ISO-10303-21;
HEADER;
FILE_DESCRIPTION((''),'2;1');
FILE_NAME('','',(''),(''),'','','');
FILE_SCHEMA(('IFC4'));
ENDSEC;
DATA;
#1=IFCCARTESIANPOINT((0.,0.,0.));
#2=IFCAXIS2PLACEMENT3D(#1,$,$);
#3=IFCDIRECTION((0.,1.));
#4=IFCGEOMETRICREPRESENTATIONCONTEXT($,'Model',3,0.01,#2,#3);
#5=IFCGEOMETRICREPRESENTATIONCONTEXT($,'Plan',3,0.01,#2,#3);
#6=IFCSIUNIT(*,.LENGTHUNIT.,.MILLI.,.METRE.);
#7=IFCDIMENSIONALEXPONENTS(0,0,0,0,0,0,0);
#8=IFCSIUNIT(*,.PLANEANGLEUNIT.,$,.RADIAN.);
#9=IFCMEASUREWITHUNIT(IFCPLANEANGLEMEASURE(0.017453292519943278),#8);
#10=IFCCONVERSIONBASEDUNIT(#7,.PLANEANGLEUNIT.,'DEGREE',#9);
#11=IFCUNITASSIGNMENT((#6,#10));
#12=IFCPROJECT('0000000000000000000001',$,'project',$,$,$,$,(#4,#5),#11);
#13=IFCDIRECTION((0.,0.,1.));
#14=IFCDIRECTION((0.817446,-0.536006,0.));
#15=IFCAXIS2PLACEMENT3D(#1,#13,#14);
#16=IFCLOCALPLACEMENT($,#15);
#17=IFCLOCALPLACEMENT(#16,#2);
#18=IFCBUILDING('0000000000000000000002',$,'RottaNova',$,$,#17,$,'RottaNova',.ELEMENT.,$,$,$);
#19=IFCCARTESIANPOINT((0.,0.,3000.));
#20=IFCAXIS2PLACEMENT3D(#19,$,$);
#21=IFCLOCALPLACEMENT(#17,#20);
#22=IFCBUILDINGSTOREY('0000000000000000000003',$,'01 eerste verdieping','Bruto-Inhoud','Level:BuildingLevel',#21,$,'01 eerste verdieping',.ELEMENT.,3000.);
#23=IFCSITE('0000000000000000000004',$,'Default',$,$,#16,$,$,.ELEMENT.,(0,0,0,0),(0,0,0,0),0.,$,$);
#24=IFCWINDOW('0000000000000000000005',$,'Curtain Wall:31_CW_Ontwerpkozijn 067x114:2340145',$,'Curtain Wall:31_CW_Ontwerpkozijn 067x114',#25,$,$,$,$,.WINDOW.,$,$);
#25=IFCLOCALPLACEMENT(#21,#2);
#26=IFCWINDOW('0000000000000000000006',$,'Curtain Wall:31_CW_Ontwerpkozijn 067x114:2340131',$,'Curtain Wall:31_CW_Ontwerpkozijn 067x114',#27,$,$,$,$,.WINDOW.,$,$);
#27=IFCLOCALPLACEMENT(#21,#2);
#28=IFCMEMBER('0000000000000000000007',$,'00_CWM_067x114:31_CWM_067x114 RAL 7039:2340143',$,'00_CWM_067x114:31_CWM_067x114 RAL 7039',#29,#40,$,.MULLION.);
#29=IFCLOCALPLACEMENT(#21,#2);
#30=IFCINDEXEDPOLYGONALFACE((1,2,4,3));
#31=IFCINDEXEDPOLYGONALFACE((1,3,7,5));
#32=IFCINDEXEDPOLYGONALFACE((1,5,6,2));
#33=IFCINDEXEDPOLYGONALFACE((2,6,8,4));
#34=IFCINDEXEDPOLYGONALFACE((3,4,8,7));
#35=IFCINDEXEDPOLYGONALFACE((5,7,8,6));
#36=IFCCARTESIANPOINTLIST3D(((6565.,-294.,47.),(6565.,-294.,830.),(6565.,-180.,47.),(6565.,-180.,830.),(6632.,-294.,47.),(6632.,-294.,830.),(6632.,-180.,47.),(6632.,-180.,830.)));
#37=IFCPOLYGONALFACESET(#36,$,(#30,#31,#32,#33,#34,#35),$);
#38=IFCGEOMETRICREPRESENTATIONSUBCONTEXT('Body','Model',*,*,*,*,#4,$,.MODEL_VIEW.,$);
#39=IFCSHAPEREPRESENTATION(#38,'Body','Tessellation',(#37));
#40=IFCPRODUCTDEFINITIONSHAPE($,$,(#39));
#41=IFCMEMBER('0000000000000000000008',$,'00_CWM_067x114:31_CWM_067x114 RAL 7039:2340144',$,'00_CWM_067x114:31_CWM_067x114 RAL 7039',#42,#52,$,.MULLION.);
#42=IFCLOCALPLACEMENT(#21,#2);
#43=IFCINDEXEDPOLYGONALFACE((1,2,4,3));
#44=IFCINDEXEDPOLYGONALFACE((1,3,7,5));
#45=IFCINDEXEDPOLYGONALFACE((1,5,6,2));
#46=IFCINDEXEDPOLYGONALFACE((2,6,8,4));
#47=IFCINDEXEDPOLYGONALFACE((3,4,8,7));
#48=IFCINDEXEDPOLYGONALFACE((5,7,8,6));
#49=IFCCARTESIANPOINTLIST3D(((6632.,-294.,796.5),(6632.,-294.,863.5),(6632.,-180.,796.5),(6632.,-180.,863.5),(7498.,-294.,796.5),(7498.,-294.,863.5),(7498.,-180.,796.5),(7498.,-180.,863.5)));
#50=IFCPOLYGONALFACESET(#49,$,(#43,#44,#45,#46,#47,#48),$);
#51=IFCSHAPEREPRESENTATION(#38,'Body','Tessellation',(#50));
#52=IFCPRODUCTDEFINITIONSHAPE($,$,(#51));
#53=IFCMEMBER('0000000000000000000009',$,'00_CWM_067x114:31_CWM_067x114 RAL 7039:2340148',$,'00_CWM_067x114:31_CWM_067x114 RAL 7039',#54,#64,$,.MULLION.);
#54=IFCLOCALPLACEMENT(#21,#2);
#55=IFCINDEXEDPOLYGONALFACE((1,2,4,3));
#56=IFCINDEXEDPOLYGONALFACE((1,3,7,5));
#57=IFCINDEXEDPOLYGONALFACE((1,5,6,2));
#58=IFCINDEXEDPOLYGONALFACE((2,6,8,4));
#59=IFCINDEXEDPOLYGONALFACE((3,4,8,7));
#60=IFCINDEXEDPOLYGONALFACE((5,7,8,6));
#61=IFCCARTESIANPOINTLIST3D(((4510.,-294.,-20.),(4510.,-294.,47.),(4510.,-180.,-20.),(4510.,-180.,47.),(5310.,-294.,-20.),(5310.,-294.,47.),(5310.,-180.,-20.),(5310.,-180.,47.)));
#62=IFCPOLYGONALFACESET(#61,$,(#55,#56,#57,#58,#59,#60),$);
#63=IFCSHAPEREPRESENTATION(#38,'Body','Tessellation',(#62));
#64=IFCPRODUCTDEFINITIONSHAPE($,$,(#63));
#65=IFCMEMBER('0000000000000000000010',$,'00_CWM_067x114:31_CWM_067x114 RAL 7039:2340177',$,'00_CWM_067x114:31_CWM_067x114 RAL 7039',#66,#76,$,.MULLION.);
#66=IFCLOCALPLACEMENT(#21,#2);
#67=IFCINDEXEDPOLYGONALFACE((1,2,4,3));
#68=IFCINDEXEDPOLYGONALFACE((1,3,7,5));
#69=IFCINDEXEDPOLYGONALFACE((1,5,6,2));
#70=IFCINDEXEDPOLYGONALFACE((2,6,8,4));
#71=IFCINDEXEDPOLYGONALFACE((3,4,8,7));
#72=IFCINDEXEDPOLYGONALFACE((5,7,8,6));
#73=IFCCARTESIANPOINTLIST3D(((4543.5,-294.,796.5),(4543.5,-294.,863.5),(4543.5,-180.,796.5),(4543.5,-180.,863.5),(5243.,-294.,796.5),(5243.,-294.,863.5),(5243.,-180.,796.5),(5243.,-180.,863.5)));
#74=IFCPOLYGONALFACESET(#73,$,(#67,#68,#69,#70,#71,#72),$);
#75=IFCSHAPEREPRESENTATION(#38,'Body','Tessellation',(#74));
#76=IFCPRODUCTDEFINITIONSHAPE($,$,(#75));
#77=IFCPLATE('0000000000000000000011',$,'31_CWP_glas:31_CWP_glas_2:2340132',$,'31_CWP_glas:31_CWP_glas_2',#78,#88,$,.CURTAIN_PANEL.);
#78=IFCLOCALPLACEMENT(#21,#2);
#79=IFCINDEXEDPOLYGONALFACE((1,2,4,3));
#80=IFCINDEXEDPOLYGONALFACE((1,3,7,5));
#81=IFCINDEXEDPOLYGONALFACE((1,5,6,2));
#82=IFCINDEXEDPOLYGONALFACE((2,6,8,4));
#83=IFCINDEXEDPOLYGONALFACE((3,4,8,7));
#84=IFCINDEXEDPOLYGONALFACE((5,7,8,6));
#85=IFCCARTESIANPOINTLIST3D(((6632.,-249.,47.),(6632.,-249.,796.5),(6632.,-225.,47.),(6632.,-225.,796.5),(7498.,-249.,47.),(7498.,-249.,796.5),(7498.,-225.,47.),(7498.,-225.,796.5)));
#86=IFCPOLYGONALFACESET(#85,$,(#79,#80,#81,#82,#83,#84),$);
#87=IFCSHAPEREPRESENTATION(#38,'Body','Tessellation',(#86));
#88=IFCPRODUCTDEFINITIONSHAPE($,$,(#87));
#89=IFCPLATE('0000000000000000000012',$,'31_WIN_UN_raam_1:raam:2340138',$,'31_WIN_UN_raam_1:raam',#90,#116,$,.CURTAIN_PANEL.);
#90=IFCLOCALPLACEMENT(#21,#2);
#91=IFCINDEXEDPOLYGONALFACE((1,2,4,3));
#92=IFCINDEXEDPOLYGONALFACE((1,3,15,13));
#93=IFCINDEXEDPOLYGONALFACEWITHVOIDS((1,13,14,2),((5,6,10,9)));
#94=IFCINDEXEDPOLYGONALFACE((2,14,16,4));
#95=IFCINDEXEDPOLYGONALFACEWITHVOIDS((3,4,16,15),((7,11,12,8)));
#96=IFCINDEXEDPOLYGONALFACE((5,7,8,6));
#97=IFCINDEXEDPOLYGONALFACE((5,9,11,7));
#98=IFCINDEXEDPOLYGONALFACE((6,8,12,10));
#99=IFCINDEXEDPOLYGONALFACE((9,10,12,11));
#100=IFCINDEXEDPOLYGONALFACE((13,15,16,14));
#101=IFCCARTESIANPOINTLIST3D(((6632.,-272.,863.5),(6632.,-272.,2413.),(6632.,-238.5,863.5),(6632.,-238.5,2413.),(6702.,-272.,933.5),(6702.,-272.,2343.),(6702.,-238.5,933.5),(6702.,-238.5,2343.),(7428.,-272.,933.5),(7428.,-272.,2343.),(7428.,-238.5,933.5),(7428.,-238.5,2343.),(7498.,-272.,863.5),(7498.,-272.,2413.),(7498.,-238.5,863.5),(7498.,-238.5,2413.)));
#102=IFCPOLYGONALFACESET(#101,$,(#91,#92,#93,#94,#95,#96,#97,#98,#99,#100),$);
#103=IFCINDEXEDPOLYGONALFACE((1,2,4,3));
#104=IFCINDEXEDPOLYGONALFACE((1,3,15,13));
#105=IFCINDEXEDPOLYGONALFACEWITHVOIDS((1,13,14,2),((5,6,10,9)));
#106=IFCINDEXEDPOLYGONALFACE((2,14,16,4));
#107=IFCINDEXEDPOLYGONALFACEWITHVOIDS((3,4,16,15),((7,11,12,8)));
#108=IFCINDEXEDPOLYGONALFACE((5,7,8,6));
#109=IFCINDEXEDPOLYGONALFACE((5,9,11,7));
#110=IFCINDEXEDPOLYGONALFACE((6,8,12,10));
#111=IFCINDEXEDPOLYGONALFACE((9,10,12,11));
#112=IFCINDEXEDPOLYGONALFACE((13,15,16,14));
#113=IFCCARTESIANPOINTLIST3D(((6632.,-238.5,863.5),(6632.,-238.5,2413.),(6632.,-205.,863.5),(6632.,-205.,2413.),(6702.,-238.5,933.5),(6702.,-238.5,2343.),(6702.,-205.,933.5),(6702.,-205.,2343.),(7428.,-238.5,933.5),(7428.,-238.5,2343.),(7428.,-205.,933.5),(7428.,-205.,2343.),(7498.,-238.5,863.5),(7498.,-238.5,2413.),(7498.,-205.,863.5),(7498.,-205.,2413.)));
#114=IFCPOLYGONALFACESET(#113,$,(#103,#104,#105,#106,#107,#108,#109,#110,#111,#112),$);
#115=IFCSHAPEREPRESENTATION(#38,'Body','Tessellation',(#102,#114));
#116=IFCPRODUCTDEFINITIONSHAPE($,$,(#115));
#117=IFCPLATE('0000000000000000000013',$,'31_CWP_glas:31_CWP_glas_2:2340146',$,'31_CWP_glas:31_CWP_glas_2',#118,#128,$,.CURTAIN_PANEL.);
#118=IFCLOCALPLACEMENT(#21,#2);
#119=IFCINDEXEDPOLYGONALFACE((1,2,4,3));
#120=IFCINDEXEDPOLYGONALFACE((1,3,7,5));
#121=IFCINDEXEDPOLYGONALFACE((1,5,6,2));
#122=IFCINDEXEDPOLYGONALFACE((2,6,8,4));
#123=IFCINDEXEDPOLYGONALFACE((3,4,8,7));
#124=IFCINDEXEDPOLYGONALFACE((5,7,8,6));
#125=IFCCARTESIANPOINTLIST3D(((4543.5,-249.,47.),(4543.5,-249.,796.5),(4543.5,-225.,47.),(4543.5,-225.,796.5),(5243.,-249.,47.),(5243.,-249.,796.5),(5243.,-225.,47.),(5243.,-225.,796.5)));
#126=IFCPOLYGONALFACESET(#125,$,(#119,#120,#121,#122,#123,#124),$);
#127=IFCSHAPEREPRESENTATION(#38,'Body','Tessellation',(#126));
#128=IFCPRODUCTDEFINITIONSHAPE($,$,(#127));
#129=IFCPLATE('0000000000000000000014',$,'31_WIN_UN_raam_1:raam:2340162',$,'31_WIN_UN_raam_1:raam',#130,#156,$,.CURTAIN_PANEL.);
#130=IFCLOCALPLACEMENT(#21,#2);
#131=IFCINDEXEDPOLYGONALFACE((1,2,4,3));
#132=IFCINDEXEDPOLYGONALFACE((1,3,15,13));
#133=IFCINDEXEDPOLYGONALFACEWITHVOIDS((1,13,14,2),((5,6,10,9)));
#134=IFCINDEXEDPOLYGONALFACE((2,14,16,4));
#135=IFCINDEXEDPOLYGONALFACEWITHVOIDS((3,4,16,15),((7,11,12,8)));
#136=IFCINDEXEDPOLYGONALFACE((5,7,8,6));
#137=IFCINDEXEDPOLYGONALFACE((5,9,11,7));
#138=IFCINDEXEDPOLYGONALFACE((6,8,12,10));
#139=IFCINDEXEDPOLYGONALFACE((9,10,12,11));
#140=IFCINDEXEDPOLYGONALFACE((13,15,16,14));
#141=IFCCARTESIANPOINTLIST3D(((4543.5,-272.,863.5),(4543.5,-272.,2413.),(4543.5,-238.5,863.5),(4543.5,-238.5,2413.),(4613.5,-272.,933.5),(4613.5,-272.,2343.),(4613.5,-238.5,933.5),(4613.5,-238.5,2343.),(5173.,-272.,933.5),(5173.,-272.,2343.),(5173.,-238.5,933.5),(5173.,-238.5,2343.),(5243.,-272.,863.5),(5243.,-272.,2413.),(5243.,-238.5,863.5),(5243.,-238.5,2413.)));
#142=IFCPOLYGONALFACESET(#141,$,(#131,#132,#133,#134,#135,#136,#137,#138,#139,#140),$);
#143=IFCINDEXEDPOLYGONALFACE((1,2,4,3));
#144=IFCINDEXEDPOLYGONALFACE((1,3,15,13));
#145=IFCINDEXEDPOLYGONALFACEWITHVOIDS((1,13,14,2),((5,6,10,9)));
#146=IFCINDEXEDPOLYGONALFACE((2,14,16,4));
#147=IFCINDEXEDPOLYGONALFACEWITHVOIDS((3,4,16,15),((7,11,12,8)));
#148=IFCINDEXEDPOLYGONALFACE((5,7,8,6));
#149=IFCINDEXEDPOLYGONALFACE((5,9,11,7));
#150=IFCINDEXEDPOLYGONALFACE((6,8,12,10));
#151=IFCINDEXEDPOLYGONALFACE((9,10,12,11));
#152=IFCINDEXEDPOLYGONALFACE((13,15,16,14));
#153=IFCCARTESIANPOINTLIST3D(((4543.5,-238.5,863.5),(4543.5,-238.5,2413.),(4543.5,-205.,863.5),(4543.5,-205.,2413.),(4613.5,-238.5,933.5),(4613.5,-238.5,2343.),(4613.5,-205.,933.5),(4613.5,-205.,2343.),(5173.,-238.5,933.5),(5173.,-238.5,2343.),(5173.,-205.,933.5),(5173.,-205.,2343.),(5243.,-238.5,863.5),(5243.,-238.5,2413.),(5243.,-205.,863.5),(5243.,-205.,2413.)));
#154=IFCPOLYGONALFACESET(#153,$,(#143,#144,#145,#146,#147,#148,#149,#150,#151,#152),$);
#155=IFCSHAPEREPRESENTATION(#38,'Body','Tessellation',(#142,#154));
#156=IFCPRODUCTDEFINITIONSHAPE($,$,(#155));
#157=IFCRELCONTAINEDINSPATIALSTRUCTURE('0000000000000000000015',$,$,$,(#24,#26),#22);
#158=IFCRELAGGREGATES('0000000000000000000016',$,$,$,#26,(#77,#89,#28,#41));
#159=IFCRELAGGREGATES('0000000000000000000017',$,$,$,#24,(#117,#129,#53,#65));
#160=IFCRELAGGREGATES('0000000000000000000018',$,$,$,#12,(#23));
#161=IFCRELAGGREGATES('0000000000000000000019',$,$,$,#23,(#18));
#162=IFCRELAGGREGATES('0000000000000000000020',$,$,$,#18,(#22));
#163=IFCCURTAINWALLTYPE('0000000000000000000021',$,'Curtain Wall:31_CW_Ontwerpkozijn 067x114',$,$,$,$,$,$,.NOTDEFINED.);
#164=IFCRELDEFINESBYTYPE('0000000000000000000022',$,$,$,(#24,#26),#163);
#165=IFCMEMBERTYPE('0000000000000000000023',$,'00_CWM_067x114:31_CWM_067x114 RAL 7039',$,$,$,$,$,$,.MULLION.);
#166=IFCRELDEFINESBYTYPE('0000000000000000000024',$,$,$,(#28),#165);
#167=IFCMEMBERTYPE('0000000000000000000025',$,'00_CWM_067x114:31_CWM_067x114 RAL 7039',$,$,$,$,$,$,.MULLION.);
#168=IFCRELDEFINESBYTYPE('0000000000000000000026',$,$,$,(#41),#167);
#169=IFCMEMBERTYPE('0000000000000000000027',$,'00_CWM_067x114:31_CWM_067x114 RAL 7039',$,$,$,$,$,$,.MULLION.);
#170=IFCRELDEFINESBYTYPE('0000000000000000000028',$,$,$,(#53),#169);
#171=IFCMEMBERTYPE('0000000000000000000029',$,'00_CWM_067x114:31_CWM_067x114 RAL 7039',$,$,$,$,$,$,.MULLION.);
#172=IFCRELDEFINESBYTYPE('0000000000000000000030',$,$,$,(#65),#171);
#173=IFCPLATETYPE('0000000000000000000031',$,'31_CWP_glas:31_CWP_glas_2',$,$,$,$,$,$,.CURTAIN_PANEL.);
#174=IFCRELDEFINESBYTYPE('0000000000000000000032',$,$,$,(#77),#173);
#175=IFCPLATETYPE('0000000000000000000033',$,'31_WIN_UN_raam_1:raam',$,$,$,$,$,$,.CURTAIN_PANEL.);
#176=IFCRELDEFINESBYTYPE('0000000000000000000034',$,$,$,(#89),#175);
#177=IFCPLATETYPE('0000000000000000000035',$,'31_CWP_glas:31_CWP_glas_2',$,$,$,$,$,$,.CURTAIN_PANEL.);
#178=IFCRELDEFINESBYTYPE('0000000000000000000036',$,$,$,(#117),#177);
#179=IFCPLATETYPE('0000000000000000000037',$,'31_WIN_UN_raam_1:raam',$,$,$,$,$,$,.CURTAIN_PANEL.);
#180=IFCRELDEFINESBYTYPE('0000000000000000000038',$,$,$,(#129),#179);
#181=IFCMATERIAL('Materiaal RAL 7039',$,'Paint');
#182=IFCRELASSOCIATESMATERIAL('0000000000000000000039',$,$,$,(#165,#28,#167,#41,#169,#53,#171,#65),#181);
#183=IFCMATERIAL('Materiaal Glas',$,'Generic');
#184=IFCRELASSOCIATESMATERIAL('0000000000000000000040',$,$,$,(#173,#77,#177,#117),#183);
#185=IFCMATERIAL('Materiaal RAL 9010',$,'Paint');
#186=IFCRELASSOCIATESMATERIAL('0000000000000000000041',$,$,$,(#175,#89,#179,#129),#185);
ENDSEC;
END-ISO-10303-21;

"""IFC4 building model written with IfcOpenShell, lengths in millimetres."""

from ifc_helpers import new_model, entity, si_unit, converted_unit, direction, frame, origin, place, context, subcontext, project, spatial, indexed_curve, outline, extrude, source, transform, mapped, material, type_object, type_shapes, element, aggregate, save


model = new_model("IFC4")

# Units and contexts
model_context = context("Model", 3, precision=0.01, world=origin(), true_north=direction((0.0, 1.0)))
plan_context = context("Plan", 3, precision=0.01, world=origin(), true_north=direction((0.0, 1.0)))
body_context = subcontext(model_context, "Body", "Model", "MODEL_VIEW")
ifc_project = project(units=[si_unit("LENGTHUNIT", "METRE", prefix="MILLI"), converted_unit("PLANEANGLEUNIT", "DEGREE", entity("IfcPlaneAngleMeasure", 0.017453292519943278), si_unit("PLANEANGLEUNIT", "RADIAN"), dimensions=[0, 0, 0, 0, 0, 0, 0])], contexts=[model_context, plan_context])

# Site, building, storey
site_placement = place(None, frame((0.0, 0.0, 0.0), z_axis=(0.0, 0.0, 1.0), x_axis=(0.817446, -0.536006, 0.0)))
site = spatial("IfcSite", under=ifc_project, at=site_placement, Name="Default", CompositionType="ELEMENT", RefLatitude=(0, 0, 0, 0), RefLongitude=(0, 0, 0, 0), RefElevation=0.0)
building_placement = place(site_placement, origin())
building = spatial("IfcBuilding", under=site, at=building_placement, Name="RottaNova", LongName="RottaNova", CompositionType="ELEMENT")
storey_placement = place(building_placement, frame((0.0, 0.0, 3000.0)))
storey = spatial("IfcBuildingStorey", under=building, at=storey_placement, Name="01 eerste verdieping", Description="Bruto-Inhoud", ObjectType="Level:BuildingLevel", LongName="01 eerste verdieping", CompositionType="ELEMENT", Elevation=3000.0)

# Windows, members
curtain_wall_type = type_object("IfcCurtainWallType", Name="Curtain Wall:31_CW_Ontwerpkozijn 067x114", PredefinedType="NOTDEFINED")
window_1_placement = place(storey_placement, frame((0.0, 0.0, -3000.0)))
window_1 = element("IfcWindow", 1, at=window_1_placement, inside=storey, type_object=curtain_wall_type, Name="Curtain Wall:31_CW_Ontwerpkozijn 067x114:2340145", ObjectType="Curtain Wall:31_CW_Ontwerpkozijn 067x114", PredefinedType="WINDOW")
ifc_material_1 = material(Name="Materiaal RAL 7039", Category="Paint")
window_2_placement = place(storey_placement, frame((0.0, 0.0, -3000.0)))
window_2 = element("IfcWindow", 2, at=window_2_placement, inside=storey, type_object=curtain_wall_type, Name="Curtain Wall:31_CW_Ontwerpkozijn 067x114:2340131", ObjectType="Curtain Wall:31_CW_Ontwerpkozijn 067x114", PredefinedType="WINDOW")
member_type_1 = type_object("IfcMemberType", Name="00_CWM_067x114:31_CWM_067x114 RAL 7039", PredefinedType="MULLION", material=ifc_material_1)
shared_shape_1 = source(origin(), body_context, "Body", "SweptSolid", [
    extrude(outline(indexed_curve([(-33.5, -57.0), (33.5, -57.0), (33.5, 57.0), (-33.5, 57.0), (-33.5, -57.0)], self_intersect=False)), frame((-33.5, 57.0, -783.0), z_axis=(0.0, 0.0, 1.0), x_axis=(-1.0, 0.0, 0.0)), (0.0, 0.0, 1.0), 783.0),
])
type_shapes(member_type_1, [shared_shape_1])
member_1_placement = place(window_2_placement, frame((6565.0, -180.0, 3830.0), z_axis=(0.0, 0.0, 1.0), x_axis=(-1.0, 0.0, 0.0)))
member_1 = element("IfcMember", 3, at=member_1_placement, type_object=member_type_1, material=ifc_material_1, Name="00_CWM_067x114:31_CWM_067x114 RAL 7039:2340143", ObjectType="00_CWM_067x114:31_CWM_067x114 RAL 7039", PredefinedType="MULLION", context=body_context, shape_type="MappedRepresentation", body=[
    mapped(shared_shape_1, transform((0.0, 0.0, 0.0), scale=1.0)),
])
member_type_2 = type_object("IfcMemberType", Name="00_CWM_067x114:31_CWM_067x114 RAL 7039", PredefinedType="MULLION", material=ifc_material_1)
shared_shape_2 = source(origin(), body_context, "Body", "SweptSolid", [
    extrude(outline(indexed_curve([(-33.5, -57.0), (33.5, -57.0), (33.5, 57.0), (-33.5, 57.0), (-33.5, -57.0)], self_intersect=False)), frame((0.0, 57.0, -866.0), z_axis=(0.0, 0.0, 1.0), x_axis=(-1.0, 0.0, 0.0)), (0.0, 0.0, 1.0), 866.0),
])
type_shapes(member_type_2, [shared_shape_2])
member_2_placement = place(window_2_placement, frame((7498.0, -180.0, 3830.0), z_axis=(1.0, 0.0, 0.0), x_axis=(0.0, 0.0, 1.0)))
member_2 = element("IfcMember", 4, at=member_2_placement, type_object=member_type_2, material=ifc_material_1, Name="00_CWM_067x114:31_CWM_067x114 RAL 7039:2340144", ObjectType="00_CWM_067x114:31_CWM_067x114 RAL 7039", PredefinedType="MULLION", context=body_context, shape_type="MappedRepresentation", body=[
    mapped(shared_shape_2, transform((0.0, 0.0, 0.0), scale=1.0)),
])

# Members
member_type_3 = type_object("IfcMemberType", Name="00_CWM_067x114:31_CWM_067x114 RAL 7039", PredefinedType="MULLION", material=ifc_material_1)
shared_shape_3 = source(origin(), body_context, "Body", "SweptSolid", [
    extrude(outline(indexed_curve([(-33.5, -57.0), (33.5, -57.0), (33.5, 57.0), (-33.5, 57.0), (-33.5, -57.0)], self_intersect=False)), frame((-33.5, -57.0, -800.0), z_axis=(0.0, 0.0, 1.0), x_axis=(-1.0, 0.0, 0.0)), (0.0, 0.0, 1.0), 800.0),
])
type_shapes(member_type_3, [shared_shape_3])
member_3_placement = place(window_1_placement, frame((5310.0, -180.0, 2980.0), z_axis=(1.0, 0.0, 0.0), x_axis=(0.0, 0.0, -1.0)))
member_3 = element("IfcMember", 5, at=member_3_placement, type_object=member_type_3, material=ifc_material_1, Name="00_CWM_067x114:31_CWM_067x114 RAL 7039:2340148", ObjectType="00_CWM_067x114:31_CWM_067x114 RAL 7039", PredefinedType="MULLION", context=body_context, shape_type="MappedRepresentation", body=[
    mapped(shared_shape_3, transform((0.0, 0.0, 0.0), scale=1.0)),
])
member_type_4 = type_object("IfcMemberType", Name="00_CWM_067x114:31_CWM_067x114 RAL 7039", PredefinedType="MULLION", material=ifc_material_1)
shared_shape_4 = source(origin(), body_context, "Body", "SweptSolid", [
    extrude(outline(indexed_curve([(-33.5, -57.0), (33.5, -57.0), (33.5, 57.0), (-33.5, 57.0), (-33.5, -57.0)], self_intersect=False)), frame((0.0, -57.0, -699.5), z_axis=(0.0, 0.0, 1.0), x_axis=(-1.0, 0.0, 0.0)), (0.0, 0.0, 1.0), 699.5),
])
type_shapes(member_type_4, [shared_shape_4])
member_4_placement = place(window_1_placement, frame((4543.5, -180.0, 3830.0), z_axis=(-1.0, 0.0, 0.0), x_axis=(0.0, 0.0, 1.0)))
member_4 = element("IfcMember", 6, at=member_4_placement, type_object=member_type_4, material=ifc_material_1, Name="00_CWM_067x114:31_CWM_067x114 RAL 7039:2340177", ObjectType="00_CWM_067x114:31_CWM_067x114 RAL 7039", PredefinedType="MULLION", context=body_context, shape_type="MappedRepresentation", body=[
    mapped(shared_shape_4, transform((0.0, 0.0, 0.0), scale=1.0)),
])

# Plates
ifc_material_2 = material(Name="Materiaal Glas", Category="Generic")
plate_type_1 = type_object("IfcPlateType", Name="31_CWP_glas:31_CWP_glas_2", PredefinedType="CURTAIN_PANEL", material=ifc_material_2)
shared_shape_5 = source(origin(), body_context, "Body", "SweptSolid", [
    extrude(outline(indexed_curve([(-12.0, -433.0), (12.0, -433.0), (12.0, 433.0), (-12.0, 433.0), (-12.0, -433.0)], self_intersect=False)), frame((0.0, -57.0, 0.0), z_axis=(0.0, 0.0, 1.0), x_axis=(0.0, 1.0, 0.0)), (0.0, 0.0, 1.0), 749.5),
])
type_shapes(plate_type_1, [shared_shape_5])
plate_1_placement = place(window_2_placement, frame((7065.0, -180.0, 3047.0)))
plate_1 = element("IfcPlate", 7, at=plate_1_placement, type_object=plate_type_1, material=ifc_material_2, Name="31_CWP_glas:31_CWP_glas_2:2340132", ObjectType="31_CWP_glas:31_CWP_glas_2", PredefinedType="CURTAIN_PANEL", context=body_context, shape_type="MappedRepresentation", body=[
    mapped(shared_shape_5, transform((0.0, 0.0, 0.0), scale=1.0)),
])
ifc_material_3 = material(Name="Materiaal RAL 9010", Category="Paint")
plate_type_2 = type_object("IfcPlateType", Name="31_WIN_UN_raam_1:raam", PredefinedType="CURTAIN_PANEL", material=ifc_material_3)
shared_shape_6 = source(origin(), body_context, "Body", "SweptSolid", [
    extrude(outline(indexed_curve([(-433.0, -774.7), (433.0, -774.7), (433.0, 774.7), (-433.0, 774.7), (-433.0, -774.7)], self_intersect=False), holes=[indexed_curve([(-363.0, 704.7), (363.0, 704.7), (363.0, -704.8), (-363.0, -704.8), (-363.0, 704.7)], self_intersect=False)]), frame((0.0, -92.0, 774.8), z_axis=(0.0, 1.0, 0.0), x_axis=(1.0, 0.0, 0.0)), (0.0, 0.0, 1.0), 33.5),
    extrude(outline(indexed_curve([(-433.0, -774.7), (433.0, -774.7), (433.0, 774.7), (-433.0, 774.7), (-433.0, -774.7)], self_intersect=False), holes=[indexed_curve([(-363.0, 704.7), (363.0, 704.7), (363.0, -704.8), (-363.0, -704.8), (-363.0, 704.7)], self_intersect=False)]), frame((0.0, -58.5, 774.8), z_axis=(0.0, 1.0, 0.0), x_axis=(1.0, 0.0, 0.0)), (0.0, 0.0, 1.0), 33.5),
])
type_shapes(plate_type_2, [shared_shape_6])
plate_2_placement = place(window_2_placement, frame((7065.0, -180.0, 3863.5)))
plate_2 = element("IfcPlate", 8, at=plate_2_placement, type_object=plate_type_2, material=ifc_material_3, Name="31_WIN_UN_raam_1:raam:2340138", ObjectType="31_WIN_UN_raam_1:raam", PredefinedType="CURTAIN_PANEL", context=body_context, shape_type="MappedRepresentation", body=[
    mapped(shared_shape_6, transform((0.0, 0.0, 0.0), scale=1.0)),
])
aggregate(window_2, [plate_1, plate_2, member_1, member_2])
plate_type_3 = type_object("IfcPlateType", Name="31_CWP_glas:31_CWP_glas_2", PredefinedType="CURTAIN_PANEL", material=ifc_material_2)
shared_shape_7 = source(origin(), body_context, "Body", "SweptSolid", [
    extrude(outline(indexed_curve([(-12.0, -349.8), (12.0, -349.8), (12.0, 349.8), (-12.0, 349.8), (-12.0, -349.8)], self_intersect=False)), frame((0.0, 57.0, 0.0), z_axis=(0.0, 0.0, 1.0), x_axis=(0.0, 1.0, 0.0)), (0.0, 0.0, 1.0), 749.5),
])
type_shapes(plate_type_3, [shared_shape_7])
plate_3_placement = place(window_1_placement, frame((4893.2, -180.0, 3047.0), z_axis=(0.0, 0.0, 1.0), x_axis=(-1.0, 0.0, 0.0)))
plate_3 = element("IfcPlate", 9, at=plate_3_placement, type_object=plate_type_3, material=ifc_material_2, Name="31_CWP_glas:31_CWP_glas_2:2340146", ObjectType="31_CWP_glas:31_CWP_glas_2", PredefinedType="CURTAIN_PANEL", context=body_context, shape_type="MappedRepresentation", body=[
    mapped(shared_shape_7, transform((0.0, 0.0, 0.0), scale=1.0)),
])
plate_type_4 = type_object("IfcPlateType", Name="31_WIN_UN_raam_1:raam", PredefinedType="CURTAIN_PANEL", material=ifc_material_3)
shared_shape_8 = source(origin(), body_context, "Body", "SweptSolid", [
    extrude(outline(indexed_curve([(-349.7, -774.8), (349.7, -774.8), (349.7, 774.8), (-349.7, 774.8), (-349.7, -774.8)], self_intersect=False), holes=[indexed_curve([(-279.7, 704.8), (279.7, 704.8), (279.7, -704.8), (-279.7, -704.8), (-279.7, 704.8)], self_intersect=False)]), frame((0.0, 58.5, 774.8), z_axis=(0.0, 1.0, 0.0), x_axis=(1.0, 0.0, 0.0)), (0.0, 0.0, 1.0), 33.5),
    extrude(outline(indexed_curve([(-349.7, -774.8), (349.7, -774.8), (349.7, 774.8), (-349.7, 774.8), (-349.7, -774.8)], self_intersect=False), holes=[indexed_curve([(-279.7, 704.7), (279.7, 704.7), (279.7, -704.8), (-279.7, -704.8), (-279.7, 704.7)], self_intersect=False)]), frame((0.0, 25.0, 774.8), z_axis=(0.0, 1.0, 0.0), x_axis=(1.0, 0.0, 0.0)), (0.0, 0.0, 1.0), 33.5),
])
type_shapes(plate_type_4, [shared_shape_8])
plate_4_placement = place(window_1_placement, frame((4893.2, -180.0, 3863.5), z_axis=(0.0, 0.0, 1.0), x_axis=(-1.0, 0.0, 0.0)))
plate_4 = element("IfcPlate", 10, at=plate_4_placement, type_object=plate_type_4, material=ifc_material_3, Name="31_WIN_UN_raam_1:raam:2340162", ObjectType="31_WIN_UN_raam_1:raam", PredefinedType="CURTAIN_PANEL", context=body_context, shape_type="MappedRepresentation", body=[
    mapped(shared_shape_8, transform((0.0, 0.0, 0.0), scale=1.0)),
])
aggregate(window_1, [plate_3, plate_4, member_3, member_4])

save(model, "model.ifc")
